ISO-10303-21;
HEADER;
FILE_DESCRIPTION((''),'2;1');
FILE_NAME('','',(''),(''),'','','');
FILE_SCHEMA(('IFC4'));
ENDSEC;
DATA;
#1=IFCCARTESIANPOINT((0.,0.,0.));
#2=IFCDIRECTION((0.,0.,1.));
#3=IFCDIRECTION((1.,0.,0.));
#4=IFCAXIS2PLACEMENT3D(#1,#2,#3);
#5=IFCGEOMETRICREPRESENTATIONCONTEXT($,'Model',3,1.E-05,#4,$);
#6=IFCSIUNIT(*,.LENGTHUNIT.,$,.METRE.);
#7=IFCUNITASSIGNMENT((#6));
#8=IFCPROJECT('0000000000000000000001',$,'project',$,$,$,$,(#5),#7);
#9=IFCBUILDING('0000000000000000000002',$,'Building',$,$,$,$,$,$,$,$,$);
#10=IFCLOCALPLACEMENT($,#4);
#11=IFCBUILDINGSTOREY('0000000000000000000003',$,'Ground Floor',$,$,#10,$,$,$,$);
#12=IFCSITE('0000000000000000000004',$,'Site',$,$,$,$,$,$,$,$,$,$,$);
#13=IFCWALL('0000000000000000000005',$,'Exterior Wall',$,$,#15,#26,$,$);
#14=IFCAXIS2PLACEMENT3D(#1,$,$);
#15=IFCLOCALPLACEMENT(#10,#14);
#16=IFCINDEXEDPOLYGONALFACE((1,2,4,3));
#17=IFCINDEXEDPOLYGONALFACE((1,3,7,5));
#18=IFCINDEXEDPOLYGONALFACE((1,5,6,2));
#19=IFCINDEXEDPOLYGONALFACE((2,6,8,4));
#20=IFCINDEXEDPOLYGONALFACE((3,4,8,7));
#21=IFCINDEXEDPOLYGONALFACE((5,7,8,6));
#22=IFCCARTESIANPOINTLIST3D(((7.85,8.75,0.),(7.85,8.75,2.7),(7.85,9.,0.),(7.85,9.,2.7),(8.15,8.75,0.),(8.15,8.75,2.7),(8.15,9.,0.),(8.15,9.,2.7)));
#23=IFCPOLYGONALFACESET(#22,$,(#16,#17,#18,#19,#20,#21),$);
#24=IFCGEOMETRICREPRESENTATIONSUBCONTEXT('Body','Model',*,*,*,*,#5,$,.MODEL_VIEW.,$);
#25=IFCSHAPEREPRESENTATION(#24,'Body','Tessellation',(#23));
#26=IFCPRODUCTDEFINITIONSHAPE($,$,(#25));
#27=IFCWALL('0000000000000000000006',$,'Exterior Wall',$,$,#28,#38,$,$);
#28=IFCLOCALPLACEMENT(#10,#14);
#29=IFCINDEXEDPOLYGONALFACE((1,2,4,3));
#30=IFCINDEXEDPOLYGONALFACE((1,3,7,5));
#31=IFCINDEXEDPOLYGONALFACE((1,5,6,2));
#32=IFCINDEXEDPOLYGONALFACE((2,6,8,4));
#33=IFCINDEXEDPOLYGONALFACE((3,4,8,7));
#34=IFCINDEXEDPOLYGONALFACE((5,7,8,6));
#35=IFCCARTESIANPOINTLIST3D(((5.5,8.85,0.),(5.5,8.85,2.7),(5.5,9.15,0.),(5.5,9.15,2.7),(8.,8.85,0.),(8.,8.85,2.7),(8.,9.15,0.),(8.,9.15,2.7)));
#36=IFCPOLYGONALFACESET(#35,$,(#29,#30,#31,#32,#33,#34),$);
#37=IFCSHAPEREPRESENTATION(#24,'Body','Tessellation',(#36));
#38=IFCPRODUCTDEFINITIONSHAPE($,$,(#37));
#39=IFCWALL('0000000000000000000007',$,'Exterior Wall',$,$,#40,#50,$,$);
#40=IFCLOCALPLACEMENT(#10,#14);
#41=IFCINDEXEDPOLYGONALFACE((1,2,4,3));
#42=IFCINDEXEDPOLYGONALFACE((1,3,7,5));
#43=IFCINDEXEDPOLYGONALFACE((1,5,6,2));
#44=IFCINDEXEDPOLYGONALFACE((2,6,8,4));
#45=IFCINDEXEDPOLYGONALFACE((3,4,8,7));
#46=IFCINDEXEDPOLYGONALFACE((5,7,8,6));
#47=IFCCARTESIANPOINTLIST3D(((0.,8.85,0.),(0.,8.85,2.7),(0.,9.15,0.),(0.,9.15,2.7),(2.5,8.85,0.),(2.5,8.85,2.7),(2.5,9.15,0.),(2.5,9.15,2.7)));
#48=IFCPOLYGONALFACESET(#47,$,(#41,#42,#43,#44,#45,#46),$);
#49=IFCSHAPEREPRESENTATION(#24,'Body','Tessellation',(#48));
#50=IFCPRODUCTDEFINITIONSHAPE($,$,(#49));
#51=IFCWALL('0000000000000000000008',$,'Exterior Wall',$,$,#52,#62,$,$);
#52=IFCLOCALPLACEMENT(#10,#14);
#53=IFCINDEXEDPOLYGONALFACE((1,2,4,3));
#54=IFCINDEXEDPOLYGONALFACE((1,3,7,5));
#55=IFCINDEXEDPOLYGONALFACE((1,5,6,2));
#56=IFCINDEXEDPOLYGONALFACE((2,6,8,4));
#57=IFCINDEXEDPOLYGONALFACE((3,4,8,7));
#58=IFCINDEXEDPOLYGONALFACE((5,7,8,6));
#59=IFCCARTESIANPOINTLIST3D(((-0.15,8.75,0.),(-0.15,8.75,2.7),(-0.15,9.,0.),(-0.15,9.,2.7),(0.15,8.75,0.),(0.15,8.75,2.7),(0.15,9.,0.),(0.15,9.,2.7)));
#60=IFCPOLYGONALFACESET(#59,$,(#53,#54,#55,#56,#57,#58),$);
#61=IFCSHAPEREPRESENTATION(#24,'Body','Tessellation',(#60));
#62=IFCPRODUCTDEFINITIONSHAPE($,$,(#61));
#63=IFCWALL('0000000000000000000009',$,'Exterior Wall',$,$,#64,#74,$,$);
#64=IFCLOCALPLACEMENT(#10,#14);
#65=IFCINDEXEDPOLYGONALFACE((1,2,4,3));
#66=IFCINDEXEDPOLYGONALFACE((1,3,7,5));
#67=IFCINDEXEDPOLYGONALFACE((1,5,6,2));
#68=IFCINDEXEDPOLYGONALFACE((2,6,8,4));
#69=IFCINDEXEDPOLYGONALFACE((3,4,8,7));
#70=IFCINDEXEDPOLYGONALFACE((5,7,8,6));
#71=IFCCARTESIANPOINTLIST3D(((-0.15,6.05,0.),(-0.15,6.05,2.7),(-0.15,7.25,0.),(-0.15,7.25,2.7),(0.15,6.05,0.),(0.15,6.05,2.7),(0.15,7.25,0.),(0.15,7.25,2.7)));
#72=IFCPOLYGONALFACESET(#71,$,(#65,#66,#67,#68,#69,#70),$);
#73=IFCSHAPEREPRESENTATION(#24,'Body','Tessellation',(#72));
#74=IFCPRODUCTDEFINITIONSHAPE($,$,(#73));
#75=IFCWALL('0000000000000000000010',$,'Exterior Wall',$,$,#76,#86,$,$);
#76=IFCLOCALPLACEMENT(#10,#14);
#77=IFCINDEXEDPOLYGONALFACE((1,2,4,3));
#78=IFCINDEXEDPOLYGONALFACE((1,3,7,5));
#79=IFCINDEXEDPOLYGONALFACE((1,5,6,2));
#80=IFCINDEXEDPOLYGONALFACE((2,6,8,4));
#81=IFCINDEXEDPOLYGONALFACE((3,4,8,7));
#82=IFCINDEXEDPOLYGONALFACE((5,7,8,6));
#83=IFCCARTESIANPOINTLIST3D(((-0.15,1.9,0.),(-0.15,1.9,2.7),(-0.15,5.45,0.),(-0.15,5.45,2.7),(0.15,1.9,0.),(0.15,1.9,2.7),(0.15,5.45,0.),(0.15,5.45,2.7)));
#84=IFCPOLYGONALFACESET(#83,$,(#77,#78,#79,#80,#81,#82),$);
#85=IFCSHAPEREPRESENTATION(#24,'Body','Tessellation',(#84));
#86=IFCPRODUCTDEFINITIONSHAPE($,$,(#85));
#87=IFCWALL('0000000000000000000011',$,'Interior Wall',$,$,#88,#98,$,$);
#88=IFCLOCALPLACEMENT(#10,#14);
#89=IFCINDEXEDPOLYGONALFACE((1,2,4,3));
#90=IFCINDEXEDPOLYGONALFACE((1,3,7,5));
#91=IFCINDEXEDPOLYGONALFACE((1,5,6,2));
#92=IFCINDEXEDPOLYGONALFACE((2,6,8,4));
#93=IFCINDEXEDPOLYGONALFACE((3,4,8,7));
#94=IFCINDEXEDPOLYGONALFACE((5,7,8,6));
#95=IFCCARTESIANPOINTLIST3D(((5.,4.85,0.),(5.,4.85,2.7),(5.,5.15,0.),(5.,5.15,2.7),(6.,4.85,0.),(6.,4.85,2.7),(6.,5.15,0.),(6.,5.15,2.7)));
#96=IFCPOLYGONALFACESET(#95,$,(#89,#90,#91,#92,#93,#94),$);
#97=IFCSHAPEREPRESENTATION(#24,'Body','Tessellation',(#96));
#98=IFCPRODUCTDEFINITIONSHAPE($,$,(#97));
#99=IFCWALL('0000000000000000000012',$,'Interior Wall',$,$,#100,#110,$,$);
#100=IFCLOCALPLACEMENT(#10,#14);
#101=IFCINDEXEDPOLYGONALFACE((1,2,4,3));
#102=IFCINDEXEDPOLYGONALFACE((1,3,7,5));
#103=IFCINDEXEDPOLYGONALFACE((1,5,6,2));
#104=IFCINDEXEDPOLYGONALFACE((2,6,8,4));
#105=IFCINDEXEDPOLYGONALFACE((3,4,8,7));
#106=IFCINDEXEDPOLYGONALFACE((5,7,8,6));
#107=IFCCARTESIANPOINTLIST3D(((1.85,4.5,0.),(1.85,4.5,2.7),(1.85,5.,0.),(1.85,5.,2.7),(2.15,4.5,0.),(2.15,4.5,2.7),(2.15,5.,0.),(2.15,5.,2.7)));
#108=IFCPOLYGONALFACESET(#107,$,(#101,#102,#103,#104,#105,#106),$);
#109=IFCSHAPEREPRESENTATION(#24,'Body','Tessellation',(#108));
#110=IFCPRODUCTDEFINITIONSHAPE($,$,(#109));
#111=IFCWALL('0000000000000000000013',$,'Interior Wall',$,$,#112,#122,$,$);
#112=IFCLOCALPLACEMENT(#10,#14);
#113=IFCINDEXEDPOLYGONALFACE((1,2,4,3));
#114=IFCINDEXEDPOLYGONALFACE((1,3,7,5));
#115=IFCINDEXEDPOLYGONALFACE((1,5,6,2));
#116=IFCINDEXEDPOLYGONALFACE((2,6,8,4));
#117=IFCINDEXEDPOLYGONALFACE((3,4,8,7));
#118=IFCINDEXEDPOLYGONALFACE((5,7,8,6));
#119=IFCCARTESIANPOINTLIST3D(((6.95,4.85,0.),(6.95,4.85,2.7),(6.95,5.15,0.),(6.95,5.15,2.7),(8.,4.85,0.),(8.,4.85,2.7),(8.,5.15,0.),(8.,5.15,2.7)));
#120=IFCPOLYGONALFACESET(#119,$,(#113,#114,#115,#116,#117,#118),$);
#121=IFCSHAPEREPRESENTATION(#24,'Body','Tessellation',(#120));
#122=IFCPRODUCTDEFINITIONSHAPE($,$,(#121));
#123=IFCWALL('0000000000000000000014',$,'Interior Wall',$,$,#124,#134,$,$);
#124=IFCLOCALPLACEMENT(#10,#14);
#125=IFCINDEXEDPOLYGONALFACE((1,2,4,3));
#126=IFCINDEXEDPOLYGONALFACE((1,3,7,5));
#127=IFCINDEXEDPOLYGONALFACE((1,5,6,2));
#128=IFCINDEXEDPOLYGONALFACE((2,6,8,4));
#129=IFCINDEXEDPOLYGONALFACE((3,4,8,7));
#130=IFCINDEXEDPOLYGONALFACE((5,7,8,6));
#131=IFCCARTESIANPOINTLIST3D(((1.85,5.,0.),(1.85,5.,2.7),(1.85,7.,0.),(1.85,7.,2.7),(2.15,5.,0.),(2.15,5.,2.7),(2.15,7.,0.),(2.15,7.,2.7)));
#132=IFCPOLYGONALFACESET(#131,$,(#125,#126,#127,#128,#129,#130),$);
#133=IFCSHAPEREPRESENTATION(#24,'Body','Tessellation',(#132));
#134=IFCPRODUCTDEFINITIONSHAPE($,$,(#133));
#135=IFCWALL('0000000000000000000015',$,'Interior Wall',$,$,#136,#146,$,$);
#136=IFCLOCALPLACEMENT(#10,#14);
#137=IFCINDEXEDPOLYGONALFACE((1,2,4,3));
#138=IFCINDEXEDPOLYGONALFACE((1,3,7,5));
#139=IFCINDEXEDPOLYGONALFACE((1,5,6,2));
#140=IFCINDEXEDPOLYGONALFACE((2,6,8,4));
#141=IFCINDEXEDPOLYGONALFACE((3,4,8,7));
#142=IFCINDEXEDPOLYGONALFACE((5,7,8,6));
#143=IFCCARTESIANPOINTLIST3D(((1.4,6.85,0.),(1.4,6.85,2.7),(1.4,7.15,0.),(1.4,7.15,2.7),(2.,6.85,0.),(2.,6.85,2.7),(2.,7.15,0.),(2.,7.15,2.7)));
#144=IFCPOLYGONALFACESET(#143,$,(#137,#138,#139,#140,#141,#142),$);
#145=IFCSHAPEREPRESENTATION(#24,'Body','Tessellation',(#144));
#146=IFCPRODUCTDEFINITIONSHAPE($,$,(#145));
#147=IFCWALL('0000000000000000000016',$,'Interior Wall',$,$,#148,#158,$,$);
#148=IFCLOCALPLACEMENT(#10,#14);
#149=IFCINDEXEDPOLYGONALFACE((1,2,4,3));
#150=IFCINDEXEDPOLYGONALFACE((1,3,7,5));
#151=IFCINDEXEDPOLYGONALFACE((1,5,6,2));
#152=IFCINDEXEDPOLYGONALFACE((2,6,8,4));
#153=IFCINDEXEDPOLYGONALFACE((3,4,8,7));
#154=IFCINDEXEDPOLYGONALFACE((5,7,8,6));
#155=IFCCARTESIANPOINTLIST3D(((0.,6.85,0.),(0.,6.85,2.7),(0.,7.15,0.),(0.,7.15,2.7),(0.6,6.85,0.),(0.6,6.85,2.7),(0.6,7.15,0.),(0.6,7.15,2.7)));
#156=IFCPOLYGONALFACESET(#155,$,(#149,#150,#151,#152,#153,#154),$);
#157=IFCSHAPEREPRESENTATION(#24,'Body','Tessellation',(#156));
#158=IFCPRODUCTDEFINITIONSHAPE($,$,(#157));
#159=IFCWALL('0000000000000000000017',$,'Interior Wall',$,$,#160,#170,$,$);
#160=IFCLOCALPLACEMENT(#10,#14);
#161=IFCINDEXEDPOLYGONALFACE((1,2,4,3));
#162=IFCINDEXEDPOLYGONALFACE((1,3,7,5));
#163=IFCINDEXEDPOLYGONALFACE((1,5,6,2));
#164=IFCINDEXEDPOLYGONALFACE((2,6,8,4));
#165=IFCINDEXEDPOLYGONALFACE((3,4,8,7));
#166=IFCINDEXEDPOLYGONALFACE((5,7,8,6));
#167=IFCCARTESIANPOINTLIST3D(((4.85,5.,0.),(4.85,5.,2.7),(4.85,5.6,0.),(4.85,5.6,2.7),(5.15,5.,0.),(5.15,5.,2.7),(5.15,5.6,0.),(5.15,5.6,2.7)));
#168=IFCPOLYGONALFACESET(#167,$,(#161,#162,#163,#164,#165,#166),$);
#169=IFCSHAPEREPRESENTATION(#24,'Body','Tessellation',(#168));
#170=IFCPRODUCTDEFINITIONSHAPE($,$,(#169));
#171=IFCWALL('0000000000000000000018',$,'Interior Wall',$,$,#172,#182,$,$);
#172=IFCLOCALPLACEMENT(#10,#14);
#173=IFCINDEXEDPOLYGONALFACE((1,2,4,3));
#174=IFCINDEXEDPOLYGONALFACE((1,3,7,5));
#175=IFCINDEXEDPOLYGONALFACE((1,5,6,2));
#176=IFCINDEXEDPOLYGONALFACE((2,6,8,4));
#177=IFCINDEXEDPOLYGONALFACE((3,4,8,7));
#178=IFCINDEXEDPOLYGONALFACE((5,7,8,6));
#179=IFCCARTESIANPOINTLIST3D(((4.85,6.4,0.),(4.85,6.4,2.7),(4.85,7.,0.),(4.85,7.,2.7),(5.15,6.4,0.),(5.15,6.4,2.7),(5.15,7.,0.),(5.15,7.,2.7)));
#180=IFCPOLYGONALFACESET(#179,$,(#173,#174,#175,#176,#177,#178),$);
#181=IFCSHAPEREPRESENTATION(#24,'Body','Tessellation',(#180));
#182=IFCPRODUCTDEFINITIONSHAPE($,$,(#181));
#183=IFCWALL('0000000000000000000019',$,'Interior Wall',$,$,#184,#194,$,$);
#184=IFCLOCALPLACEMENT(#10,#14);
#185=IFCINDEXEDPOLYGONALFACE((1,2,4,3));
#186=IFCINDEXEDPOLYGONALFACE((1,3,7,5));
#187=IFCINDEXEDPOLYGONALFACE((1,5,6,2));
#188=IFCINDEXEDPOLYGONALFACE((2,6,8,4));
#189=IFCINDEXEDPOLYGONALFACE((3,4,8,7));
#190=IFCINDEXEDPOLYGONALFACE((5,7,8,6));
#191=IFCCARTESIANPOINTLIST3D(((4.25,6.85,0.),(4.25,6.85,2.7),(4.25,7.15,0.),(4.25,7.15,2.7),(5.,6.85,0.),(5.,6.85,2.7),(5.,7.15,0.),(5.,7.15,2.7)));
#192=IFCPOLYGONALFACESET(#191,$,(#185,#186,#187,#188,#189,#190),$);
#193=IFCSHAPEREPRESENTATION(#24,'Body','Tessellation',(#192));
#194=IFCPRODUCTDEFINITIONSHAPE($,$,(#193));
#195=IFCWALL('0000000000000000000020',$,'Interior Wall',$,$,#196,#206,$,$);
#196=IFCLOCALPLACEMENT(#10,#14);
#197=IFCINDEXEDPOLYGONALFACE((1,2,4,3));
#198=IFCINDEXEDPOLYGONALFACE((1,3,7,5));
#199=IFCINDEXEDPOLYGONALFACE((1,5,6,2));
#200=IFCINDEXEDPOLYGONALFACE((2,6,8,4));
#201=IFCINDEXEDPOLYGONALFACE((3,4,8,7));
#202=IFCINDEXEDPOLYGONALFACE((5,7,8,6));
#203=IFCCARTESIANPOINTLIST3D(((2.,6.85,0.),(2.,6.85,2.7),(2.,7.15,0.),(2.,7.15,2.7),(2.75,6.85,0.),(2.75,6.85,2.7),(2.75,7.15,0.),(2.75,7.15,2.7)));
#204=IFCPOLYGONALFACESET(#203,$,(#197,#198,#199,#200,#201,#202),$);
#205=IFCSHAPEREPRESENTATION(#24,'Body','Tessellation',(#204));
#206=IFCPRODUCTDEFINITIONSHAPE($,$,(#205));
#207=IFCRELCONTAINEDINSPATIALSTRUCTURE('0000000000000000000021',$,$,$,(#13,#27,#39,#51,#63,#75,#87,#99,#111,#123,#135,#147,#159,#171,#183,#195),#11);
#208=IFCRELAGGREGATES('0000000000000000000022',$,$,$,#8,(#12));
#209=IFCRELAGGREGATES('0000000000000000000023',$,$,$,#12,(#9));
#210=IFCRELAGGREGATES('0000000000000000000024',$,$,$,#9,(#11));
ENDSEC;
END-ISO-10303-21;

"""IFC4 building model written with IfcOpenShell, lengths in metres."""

from ifc_helpers import new_model, si_unit, frame, origin_with_axes, place, context, subcontext, project, spatial, indexed_curve, outline, extrude, element, save


model = new_model("IFC4")

# Units and contexts
model_context = context("Model", 3, precision=1e-05, world=origin_with_axes())
body_context = subcontext(model_context, "Body", "Model", "MODEL_VIEW")
ifc_project = project(units=[si_unit("LENGTHUNIT", "METRE")], contexts=[model_context])

# Site, building, storey
site = spatial("IfcSite", under=ifc_project, Name="Site")
building = spatial("IfcBuilding", under=site, Name="Building")
storey_placement = place(None, origin_with_axes())
storey = spatial("IfcBuildingStorey", under=building, at=storey_placement, Name="Ground Floor")

# Walls
wall_1_placement = place(storey_placement, frame((8.0, 8.75, 0.0), z_axis=(0.0, 0.0, 1.0), x_axis=(0.0, 1.0, 0.0)))
element("IfcWall", 1, at=wall_1_placement, inside=storey, Name="Exterior Wall", context=body_context, shape_type="SweptSolid", body=[
    extrude(outline(indexed_curve([(0.0, 0.0), (0.0, 0.3), (0.25, 0.3), (0.25, 0.0), (0.0, 0.0)], self_intersect=False)), frame((0.0, -0.15, 0.0), z_axis=(0.0, 0.0, 1.0), x_axis=(1.0, 0.0, 0.0)), (0.0, 0.0, 1.0), 2.7),
])
for number, where, z_axis, x_axis, name in (
    (2, (8.0, 9.0, 0.0), (0.0, 0.0, 1.0), (-1.0, 0.0, 0.0), "Exterior Wall"),
    (3, (2.5, 9.0, 0.0), (0.0, 0.0, 1.0), (-1.0, 0.0, 0.0), "Exterior Wall"),
):
    element("IfcWall", number, at=place(storey_placement, frame(where, z_axis=z_axis, x_axis=x_axis)), inside=storey, Name=name, context=body_context, shape_type="SweptSolid", body=[
        extrude(outline(indexed_curve([(0.0, 0.0), (0.0, 0.3), (2.5, 0.3), (2.5, 0.0), (0.0, 0.0)], self_intersect=False)), frame((0.0, -0.15, 0.0), z_axis=(0.0, 0.0, 1.0), x_axis=(1.0, 0.0, 0.0)), (0.0, 0.0, 1.0), 2.7),
    ])
wall_2_placement = place(storey_placement, frame((0.0, 9.0, 0.0), z_axis=(0.0, 0.0, 1.0), x_axis=(0.0, -1.0, 0.0)))
element("IfcWall", 4, at=wall_2_placement, inside=storey, Name="Exterior Wall", context=body_context, shape_type="SweptSolid", body=[
    extrude(outline(indexed_curve([(0.0, 0.0), (0.0, 0.3), (0.25, 0.3), (0.25, 0.0), (0.0, 0.0)], self_intersect=False)), frame((0.0, -0.15, 0.0), z_axis=(0.0, 0.0, 1.0), x_axis=(1.0, 0.0, 0.0)), (0.0, 0.0, 1.0), 2.7),
])
wall_3_placement = place(storey_placement, frame((0.0, 7.25, 0.0), z_axis=(0.0, 0.0, 1.0), x_axis=(0.0, -1.0, 0.0)))
element("IfcWall", 5, at=wall_3_placement, inside=storey, Name="Exterior Wall", context=body_context, shape_type="SweptSolid", body=[
    extrude(outline(indexed_curve([(0.0, 0.0), (0.0, 0.3), (1.2, 0.3), (1.2, 0.0), (0.0, 0.0)], self_intersect=False)), frame((0.0, -0.15, 0.0), z_axis=(0.0, 0.0, 1.0), x_axis=(1.0, 0.0, 0.0)), (0.0, 0.0, 1.0), 2.7),
])
wall_4_placement = place(storey_placement, frame((0.0, 5.45, 0.0), z_axis=(0.0, 0.0, 1.0), x_axis=(0.0, -1.0, 0.0)))
element("IfcWall", 6, at=wall_4_placement, inside=storey, Name="Exterior Wall", context=body_context, shape_type="SweptSolid", body=[
    extrude(outline(indexed_curve([(0.0, 0.0), (0.0, 0.3), (3.55, 0.3), (3.55, 0.0), (0.0, 0.0)], self_intersect=False)), frame((0.0, -0.15, 0.0), z_axis=(0.0, 0.0, 1.0), x_axis=(1.0, 0.0, 0.0)), (0.0, 0.0, 1.0), 2.7),
])
wall_5_placement = place(storey_placement, frame((6.0, 5.0, 0.0), z_axis=(0.0, 0.0, 1.0), x_axis=(-1.0, 0.0, 0.0)))
element("IfcWall", 7, at=wall_5_placement, inside=storey, Name="Interior Wall", context=body_context, shape_type="SweptSolid", body=[
    extrude(outline(indexed_curve([(0.0, 0.0), (0.0, 0.3), (1.0, 0.3), (1.0, 0.0), (0.0, 0.0)], self_intersect=False)), frame((0.0, -0.15, 0.0), z_axis=(0.0, 0.0, 1.0), x_axis=(1.0, 0.0, 0.0)), (0.0, 0.0, 1.0), 2.7),
])
wall_6_placement = place(storey_placement, frame((2.0, 5.0, 0.0), z_axis=(0.0, 0.0, 1.0), x_axis=(0.0, -1.0, 0.0)))
element("IfcWall", 8, at=wall_6_placement, inside=storey, Name="Interior Wall", context=body_context, shape_type="SweptSolid", body=[
    extrude(outline(indexed_curve([(0.0, 0.0), (0.0, 0.3), (0.5, 0.3), (0.5, 0.0), (0.0, 0.0)], self_intersect=False)), frame((0.0, -0.15, 0.0), z_axis=(0.0, 0.0, 1.0), x_axis=(1.0, 0.0, 0.0)), (0.0, 0.0, 1.0), 2.7),
])
wall_7_placement = place(storey_placement, frame((8.0, 5.0, 0.0), z_axis=(0.0, 0.0, 1.0), x_axis=(-1.0, 0.0, 0.0)))
element("IfcWall", 9, at=wall_7_placement, inside=storey, Name="Interior Wall", context=body_context, shape_type="SweptSolid", body=[
    extrude(outline(indexed_curve([(0.0, 0.0), (0.0, 0.3), (1.05, 0.3), (1.05, 0.0), (0.0, 0.0)], self_intersect=False)), frame((0.0, -0.15, 0.0), z_axis=(0.0, 0.0, 1.0), x_axis=(1.0, 0.0, 0.0)), (0.0, 0.0, 1.0), 2.7),
])
wall_8_placement = place(storey_placement, frame((2.0, 5.0, 0.0), z_axis=(0.0, 0.0, 1.0), x_axis=(0.0, 1.0, 0.0)))
element("IfcWall", 10, at=wall_8_placement, inside=storey, Name="Interior Wall", context=body_context, shape_type="SweptSolid", body=[
    extrude(outline(indexed_curve([(0.0, 0.0), (0.0, 0.3), (2.0, 0.3), (2.0, 0.0), (0.0, 0.0)], self_intersect=False)), frame((0.0, -0.15, 0.0), z_axis=(0.0, 0.0, 1.0), x_axis=(1.0, 0.0, 0.0)), (0.0, 0.0, 1.0), 2.7),
])
for number, where, z_axis, x_axis, name in (
    (11, (2.0, 7.0, 0.0), (0.0, 0.0, 1.0), (-1.0, 0.0, 0.0), "Interior Wall"),
    (12, (0.6, 7.0, 0.0), (0.0, 0.0, 1.0), (-1.0, 0.0, 0.0), "Interior Wall"),
):
    element("IfcWall", number, at=place(storey_placement, frame(where, z_axis=z_axis, x_axis=x_axis)), inside=storey, Name=name, context=body_context, shape_type="SweptSolid", body=[
        extrude(outline(indexed_curve([(0.0, 0.0), (0.0, 0.3), (0.6, 0.3), (0.6, 0.0), (0.0, 0.0)], self_intersect=False)), frame((0.0, -0.15, 0.0), z_axis=(0.0, 0.0, 1.0), x_axis=(1.0, 0.0, 0.0)), (0.0, 0.0, 1.0), 2.7),
    ])
for number, where, z_axis, x_axis, name in (
    (13, (5.0, 5.0, 0.0), (0.0, 0.0, 1.0), (0.0, 1.0, 0.0), "Interior Wall"),
    (14, (5.0, 6.4, 0.0), (0.0, 0.0, 1.0), (0.0, 1.0, 0.0), "Interior Wall"),
):
    element("IfcWall", number, at=place(storey_placement, frame(where, z_axis=z_axis, x_axis=x_axis)), inside=storey, Name=name, context=body_context, shape_type="SweptSolid", body=[
        extrude(outline(indexed_curve([(0.0, 0.0), (0.0, 0.3), (0.6, 0.3), (0.6, 0.0), (0.0, 0.0)], self_intersect=False)), frame((0.0, -0.15, 0.0), z_axis=(0.0, 0.0, 1.0), x_axis=(1.0, 0.0, 0.0)), (0.0, 0.0, 1.0), 2.7),
    ])
for number, where, z_axis, x_axis, name in (
    (15, (5.0, 7.0, 0.0), (0.0, 0.0, 1.0), (-1.0, 0.0, 0.0), "Interior Wall"),
    (16, (2.75, 7.0, 0.0), (0.0, 0.0, 1.0), (-1.0, 0.0, 0.0), "Interior Wall"),
):
    element("IfcWall", number, at=place(storey_placement, frame(where, z_axis=z_axis, x_axis=x_axis)), inside=storey, Name=name, context=body_context, shape_type="SweptSolid", body=[
        extrude(outline(indexed_curve([(0.0, 0.0), (0.0, 0.3), (0.75, 0.3), (0.75, 0.0), (0.0, 0.0)], self_intersect=False)), frame((0.0, -0.15, 0.0), z_axis=(0.0, 0.0, 1.0), x_axis=(1.0, 0.0, 0.0)), (0.0, 0.0, 1.0), 2.7),
    ])

save(model, "model.ifc")
